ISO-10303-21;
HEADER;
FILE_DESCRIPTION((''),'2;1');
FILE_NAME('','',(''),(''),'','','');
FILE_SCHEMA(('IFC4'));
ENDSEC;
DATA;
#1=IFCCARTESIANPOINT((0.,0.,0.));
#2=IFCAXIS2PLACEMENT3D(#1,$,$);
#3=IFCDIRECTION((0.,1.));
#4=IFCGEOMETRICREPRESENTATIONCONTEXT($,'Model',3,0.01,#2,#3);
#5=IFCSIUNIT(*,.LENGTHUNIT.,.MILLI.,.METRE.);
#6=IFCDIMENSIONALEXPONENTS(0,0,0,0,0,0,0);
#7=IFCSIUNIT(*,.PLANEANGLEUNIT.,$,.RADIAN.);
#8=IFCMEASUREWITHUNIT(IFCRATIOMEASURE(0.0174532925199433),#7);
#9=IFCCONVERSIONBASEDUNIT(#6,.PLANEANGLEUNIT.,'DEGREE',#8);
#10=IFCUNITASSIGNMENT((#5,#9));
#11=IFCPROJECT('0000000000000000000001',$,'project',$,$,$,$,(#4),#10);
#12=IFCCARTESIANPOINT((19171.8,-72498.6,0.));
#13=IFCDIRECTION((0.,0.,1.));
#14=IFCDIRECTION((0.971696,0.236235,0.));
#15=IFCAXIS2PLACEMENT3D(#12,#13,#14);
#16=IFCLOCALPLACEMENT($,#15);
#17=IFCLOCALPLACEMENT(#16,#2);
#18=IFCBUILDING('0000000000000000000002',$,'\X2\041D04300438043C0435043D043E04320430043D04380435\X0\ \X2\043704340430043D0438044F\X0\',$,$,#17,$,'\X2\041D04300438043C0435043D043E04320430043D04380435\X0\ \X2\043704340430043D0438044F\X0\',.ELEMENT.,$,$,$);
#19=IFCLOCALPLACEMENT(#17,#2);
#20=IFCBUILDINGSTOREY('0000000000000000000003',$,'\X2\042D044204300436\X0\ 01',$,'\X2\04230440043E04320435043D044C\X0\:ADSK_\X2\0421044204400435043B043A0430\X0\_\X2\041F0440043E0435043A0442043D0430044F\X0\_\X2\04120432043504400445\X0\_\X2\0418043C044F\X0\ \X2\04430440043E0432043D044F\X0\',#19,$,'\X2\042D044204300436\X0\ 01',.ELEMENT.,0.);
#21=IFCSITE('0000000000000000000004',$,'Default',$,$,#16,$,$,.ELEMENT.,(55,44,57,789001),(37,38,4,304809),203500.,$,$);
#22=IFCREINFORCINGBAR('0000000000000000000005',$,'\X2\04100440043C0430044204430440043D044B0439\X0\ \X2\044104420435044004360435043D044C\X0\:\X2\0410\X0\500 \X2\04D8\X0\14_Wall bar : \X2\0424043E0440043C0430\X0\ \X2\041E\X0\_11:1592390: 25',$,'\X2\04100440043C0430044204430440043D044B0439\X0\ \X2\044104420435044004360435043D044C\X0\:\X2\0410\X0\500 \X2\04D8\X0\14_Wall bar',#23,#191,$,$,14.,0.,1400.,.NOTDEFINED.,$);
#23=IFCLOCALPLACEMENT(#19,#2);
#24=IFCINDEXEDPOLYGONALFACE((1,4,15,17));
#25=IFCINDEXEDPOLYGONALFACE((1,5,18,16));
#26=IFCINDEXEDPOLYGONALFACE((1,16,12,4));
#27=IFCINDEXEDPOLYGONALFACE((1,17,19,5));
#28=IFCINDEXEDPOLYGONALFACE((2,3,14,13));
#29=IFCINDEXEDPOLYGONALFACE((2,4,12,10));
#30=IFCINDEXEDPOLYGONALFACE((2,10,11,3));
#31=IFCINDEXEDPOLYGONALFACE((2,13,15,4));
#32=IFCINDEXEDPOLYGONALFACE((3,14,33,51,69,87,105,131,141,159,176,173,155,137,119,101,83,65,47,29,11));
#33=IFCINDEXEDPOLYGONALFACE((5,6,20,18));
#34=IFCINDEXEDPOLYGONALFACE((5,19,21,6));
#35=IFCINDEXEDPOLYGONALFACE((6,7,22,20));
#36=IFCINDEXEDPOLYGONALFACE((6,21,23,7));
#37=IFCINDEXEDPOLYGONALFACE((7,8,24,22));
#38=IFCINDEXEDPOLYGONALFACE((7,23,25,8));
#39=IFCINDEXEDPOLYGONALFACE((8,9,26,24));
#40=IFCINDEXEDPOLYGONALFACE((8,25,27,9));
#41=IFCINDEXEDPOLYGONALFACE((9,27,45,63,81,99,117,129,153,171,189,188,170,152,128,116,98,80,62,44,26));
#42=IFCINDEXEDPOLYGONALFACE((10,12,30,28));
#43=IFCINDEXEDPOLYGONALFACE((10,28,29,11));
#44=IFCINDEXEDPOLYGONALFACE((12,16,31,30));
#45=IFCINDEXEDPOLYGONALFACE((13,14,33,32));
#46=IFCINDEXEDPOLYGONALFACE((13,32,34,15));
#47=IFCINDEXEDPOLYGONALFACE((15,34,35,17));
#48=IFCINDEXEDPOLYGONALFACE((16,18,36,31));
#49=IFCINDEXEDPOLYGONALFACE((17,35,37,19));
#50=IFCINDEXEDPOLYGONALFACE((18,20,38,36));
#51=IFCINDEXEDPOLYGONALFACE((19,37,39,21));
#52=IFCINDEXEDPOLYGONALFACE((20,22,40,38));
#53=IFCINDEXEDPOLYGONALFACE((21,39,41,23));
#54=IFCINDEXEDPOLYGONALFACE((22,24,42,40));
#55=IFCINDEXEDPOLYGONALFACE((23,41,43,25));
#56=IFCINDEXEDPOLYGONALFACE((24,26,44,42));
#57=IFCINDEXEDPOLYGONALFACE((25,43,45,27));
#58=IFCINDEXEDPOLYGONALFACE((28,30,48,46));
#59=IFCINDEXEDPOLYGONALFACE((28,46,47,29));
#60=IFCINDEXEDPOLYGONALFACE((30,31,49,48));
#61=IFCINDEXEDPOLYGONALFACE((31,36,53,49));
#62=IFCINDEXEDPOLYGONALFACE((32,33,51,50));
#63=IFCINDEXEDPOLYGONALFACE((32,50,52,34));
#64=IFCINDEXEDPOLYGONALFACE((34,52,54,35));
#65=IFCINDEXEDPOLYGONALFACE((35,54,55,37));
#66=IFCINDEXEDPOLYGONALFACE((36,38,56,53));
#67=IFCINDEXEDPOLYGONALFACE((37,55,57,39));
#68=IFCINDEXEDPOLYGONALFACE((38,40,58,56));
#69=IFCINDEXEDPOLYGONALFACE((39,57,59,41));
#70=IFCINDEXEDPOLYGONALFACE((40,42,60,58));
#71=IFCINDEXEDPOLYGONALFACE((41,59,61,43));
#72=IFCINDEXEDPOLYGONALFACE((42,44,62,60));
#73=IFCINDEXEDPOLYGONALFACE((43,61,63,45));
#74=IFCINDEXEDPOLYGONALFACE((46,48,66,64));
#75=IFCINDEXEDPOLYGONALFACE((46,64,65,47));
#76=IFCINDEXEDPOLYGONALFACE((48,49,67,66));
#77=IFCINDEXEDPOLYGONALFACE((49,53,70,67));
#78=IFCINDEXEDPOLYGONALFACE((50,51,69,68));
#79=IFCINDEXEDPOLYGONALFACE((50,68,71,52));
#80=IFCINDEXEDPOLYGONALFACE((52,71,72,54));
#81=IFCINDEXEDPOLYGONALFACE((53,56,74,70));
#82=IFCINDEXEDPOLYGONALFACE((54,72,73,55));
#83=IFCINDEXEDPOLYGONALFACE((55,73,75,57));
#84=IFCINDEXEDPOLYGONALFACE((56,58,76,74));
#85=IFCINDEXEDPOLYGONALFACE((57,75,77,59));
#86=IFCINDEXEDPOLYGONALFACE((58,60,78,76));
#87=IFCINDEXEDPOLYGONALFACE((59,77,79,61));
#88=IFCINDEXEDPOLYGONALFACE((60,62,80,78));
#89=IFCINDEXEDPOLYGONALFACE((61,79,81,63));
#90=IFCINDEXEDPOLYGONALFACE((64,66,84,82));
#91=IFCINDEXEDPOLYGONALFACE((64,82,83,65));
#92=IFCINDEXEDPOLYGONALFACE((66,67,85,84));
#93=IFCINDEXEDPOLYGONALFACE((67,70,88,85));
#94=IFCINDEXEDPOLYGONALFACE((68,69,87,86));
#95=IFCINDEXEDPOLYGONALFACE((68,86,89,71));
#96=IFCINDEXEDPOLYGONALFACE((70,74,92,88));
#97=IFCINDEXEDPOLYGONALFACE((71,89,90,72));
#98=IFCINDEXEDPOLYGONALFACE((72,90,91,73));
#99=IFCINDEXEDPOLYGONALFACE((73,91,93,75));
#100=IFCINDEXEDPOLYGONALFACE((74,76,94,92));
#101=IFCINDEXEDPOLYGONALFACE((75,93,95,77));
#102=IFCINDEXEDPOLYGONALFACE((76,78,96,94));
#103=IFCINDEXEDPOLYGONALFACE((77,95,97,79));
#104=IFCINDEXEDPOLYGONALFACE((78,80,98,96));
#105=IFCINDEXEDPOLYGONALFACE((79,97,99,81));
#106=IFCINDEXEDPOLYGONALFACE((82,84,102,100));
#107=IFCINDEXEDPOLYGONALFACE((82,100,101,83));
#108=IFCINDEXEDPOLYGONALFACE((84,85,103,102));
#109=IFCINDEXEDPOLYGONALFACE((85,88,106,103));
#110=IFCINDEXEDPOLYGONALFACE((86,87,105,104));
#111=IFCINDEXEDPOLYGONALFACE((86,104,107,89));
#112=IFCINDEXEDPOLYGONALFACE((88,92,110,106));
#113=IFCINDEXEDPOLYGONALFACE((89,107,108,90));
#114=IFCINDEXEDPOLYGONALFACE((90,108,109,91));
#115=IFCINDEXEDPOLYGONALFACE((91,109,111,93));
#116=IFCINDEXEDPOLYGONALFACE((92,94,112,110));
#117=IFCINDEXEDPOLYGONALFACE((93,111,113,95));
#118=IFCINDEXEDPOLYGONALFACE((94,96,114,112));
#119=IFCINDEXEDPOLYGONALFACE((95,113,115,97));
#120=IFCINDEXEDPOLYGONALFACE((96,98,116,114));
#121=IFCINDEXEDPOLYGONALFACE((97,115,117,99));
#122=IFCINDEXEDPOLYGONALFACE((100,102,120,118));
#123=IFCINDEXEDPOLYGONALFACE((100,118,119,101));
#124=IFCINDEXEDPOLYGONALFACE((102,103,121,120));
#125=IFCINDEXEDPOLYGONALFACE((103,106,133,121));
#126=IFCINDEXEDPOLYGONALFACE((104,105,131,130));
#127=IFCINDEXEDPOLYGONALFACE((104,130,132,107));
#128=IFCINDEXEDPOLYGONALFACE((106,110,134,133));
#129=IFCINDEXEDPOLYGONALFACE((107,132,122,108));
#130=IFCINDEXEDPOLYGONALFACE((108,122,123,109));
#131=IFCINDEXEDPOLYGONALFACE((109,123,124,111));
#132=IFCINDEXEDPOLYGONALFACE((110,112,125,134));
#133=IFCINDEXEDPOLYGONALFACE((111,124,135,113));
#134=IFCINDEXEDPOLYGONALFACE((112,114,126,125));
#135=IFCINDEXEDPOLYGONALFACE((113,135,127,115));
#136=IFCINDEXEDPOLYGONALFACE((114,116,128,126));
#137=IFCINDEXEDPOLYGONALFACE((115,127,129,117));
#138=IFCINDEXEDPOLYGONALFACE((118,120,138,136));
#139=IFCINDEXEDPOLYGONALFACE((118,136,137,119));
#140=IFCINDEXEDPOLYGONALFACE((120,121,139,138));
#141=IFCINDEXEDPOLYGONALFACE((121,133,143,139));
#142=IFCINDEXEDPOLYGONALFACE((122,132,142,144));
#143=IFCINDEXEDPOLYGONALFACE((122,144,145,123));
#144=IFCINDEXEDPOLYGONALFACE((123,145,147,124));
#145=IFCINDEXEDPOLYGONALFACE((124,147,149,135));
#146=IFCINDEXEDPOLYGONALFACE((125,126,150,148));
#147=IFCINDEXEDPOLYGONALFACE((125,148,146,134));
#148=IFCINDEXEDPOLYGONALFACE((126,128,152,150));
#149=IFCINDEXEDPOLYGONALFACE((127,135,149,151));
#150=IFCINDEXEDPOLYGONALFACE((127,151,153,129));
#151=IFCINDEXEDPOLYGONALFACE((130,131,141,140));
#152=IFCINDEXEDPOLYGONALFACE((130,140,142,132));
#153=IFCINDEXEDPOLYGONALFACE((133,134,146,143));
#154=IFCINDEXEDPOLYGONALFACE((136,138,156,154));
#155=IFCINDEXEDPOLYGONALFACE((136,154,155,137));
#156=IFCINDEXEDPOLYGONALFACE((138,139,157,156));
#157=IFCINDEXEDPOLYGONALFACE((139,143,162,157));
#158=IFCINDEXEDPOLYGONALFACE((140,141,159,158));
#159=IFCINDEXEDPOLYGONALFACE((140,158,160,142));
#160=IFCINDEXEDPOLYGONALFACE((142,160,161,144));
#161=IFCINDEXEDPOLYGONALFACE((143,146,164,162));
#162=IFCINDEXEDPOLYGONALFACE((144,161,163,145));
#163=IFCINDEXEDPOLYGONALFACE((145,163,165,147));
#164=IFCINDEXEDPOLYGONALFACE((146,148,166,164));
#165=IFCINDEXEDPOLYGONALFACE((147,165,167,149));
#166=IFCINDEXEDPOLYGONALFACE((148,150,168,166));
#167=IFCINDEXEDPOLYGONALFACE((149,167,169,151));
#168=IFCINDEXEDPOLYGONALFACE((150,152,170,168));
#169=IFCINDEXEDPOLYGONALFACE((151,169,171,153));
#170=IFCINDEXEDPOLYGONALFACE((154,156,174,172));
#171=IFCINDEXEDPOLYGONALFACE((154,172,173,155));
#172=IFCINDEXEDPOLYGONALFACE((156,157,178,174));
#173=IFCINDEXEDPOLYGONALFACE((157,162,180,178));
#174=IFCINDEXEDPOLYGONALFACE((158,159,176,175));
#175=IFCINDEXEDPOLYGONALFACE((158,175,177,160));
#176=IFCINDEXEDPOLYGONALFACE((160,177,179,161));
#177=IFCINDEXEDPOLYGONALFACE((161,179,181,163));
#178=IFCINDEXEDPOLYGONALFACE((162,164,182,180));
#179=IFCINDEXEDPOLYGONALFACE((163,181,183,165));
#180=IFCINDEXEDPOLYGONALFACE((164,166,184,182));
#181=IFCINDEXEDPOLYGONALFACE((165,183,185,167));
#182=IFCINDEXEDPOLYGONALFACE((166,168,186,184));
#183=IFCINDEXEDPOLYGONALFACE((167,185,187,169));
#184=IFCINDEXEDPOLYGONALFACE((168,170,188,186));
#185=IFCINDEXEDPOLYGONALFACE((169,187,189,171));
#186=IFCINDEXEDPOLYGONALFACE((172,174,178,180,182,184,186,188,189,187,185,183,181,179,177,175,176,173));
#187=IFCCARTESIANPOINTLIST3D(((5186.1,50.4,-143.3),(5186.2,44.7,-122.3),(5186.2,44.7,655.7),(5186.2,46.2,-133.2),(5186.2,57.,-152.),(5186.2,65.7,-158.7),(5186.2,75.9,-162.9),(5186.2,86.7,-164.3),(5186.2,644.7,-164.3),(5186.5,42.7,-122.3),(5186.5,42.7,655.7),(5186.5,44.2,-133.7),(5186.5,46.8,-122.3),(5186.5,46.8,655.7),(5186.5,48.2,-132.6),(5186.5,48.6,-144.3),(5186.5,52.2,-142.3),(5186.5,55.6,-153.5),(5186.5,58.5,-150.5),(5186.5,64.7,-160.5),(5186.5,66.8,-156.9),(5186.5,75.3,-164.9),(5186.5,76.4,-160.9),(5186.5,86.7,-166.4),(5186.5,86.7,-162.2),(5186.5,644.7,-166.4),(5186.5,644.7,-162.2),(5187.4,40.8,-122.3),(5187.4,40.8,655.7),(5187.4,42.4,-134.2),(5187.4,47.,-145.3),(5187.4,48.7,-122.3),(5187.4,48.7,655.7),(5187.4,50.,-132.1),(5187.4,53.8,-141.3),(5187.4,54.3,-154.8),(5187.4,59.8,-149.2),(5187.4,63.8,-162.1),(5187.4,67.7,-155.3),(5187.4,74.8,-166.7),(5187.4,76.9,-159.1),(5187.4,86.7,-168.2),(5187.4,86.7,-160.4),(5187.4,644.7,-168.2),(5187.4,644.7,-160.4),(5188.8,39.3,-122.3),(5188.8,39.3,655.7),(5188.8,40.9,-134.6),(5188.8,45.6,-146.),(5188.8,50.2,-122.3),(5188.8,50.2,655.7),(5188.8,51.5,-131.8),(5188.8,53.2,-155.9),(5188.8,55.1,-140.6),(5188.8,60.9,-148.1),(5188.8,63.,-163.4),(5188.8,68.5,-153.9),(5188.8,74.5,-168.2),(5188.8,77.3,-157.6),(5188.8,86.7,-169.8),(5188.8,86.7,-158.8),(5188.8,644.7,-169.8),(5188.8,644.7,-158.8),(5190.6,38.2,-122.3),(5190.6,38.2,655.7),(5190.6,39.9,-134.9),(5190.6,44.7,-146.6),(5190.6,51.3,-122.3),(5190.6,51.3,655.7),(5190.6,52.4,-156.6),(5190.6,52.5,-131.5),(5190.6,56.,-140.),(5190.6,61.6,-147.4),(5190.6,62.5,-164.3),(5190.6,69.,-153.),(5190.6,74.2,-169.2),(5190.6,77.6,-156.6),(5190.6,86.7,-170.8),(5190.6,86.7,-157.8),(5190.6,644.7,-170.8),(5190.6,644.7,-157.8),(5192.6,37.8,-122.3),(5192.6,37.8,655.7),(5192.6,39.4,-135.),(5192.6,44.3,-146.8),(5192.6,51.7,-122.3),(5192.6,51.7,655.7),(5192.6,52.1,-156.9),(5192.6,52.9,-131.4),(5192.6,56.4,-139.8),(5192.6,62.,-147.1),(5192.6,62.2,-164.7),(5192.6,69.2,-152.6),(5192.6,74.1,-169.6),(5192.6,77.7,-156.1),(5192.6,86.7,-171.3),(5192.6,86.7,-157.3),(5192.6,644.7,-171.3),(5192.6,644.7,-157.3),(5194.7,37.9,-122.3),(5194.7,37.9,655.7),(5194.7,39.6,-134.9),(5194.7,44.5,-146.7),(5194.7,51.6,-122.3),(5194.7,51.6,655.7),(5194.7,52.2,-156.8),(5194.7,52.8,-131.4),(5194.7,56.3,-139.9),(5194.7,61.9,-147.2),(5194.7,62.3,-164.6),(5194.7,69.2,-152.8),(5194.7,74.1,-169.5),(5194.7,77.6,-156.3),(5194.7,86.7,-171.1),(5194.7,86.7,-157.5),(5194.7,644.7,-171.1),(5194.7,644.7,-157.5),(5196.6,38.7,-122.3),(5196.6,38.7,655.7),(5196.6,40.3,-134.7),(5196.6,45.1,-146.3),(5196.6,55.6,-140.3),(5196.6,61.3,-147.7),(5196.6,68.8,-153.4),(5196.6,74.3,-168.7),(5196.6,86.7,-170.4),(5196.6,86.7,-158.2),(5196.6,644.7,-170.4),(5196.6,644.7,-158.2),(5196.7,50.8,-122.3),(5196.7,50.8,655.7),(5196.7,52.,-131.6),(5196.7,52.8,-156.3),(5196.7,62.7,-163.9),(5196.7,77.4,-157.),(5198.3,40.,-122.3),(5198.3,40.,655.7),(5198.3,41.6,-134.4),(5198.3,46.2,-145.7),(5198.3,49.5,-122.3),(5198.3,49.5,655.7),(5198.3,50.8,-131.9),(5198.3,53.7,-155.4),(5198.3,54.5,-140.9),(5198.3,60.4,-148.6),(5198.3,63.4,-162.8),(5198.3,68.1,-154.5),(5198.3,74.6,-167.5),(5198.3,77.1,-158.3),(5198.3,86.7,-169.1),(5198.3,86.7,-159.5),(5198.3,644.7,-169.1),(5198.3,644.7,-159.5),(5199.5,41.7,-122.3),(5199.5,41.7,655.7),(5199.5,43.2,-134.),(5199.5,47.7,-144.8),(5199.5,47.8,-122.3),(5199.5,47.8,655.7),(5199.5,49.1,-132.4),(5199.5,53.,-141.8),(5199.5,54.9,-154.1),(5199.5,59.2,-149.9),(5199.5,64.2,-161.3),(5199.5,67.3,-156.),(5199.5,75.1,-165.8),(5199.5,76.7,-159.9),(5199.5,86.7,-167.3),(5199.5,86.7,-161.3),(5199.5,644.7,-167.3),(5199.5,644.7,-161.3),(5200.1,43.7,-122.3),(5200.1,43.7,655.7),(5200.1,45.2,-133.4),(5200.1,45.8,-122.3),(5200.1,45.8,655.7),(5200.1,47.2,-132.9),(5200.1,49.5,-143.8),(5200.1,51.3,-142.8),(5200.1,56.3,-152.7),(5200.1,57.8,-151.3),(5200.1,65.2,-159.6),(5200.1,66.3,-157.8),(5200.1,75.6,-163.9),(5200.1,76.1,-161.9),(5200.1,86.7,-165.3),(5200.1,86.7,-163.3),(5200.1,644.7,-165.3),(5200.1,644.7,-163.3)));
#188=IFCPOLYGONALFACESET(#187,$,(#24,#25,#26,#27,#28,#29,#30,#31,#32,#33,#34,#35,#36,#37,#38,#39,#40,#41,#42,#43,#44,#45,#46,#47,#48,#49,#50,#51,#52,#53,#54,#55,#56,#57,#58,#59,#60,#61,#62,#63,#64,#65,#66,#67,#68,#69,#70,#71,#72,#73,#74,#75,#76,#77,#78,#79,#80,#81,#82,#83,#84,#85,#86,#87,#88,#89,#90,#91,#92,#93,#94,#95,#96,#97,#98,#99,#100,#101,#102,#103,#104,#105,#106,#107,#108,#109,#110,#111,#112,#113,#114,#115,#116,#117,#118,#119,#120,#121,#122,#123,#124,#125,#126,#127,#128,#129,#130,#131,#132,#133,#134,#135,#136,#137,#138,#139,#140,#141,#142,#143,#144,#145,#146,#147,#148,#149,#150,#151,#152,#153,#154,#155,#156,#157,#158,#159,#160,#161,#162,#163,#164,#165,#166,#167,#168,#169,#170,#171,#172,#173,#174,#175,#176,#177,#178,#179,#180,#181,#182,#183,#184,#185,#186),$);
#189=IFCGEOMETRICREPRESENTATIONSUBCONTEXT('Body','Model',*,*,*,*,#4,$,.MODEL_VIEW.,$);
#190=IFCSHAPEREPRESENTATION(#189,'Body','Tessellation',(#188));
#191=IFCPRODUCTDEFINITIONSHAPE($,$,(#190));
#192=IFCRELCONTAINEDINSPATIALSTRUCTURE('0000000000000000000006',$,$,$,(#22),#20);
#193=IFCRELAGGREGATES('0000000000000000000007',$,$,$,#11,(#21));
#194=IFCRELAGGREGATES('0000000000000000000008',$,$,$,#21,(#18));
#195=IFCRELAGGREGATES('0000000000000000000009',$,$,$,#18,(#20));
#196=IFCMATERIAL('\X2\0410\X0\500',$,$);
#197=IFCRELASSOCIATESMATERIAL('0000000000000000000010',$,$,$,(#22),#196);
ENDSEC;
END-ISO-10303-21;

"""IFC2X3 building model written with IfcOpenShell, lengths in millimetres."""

from ifc_helpers import new_model, entity, si_unit, converted_unit, direction, frame, origin, place, context, subcontext, project, spatial, material, element, save


model = new_model("IFC2X3")

# Units and contexts
model_context = context("Model", 3, precision=0.01, world=origin(), true_north=direction((0.0, 1.0)))
body_context = subcontext(model_context, "Body", "Model", "MODEL_VIEW")
ifc_project = project(units=[si_unit("LENGTHUNIT", "METRE", prefix="MILLI"), converted_unit("PLANEANGLEUNIT", "DEGREE", entity("IfcRatioMeasure", 0.0174532925199433), si_unit("PLANEANGLEUNIT", "RADIAN"), dimensions=[0, 0, 0, 0, 0, 0, 0])], contexts=[model_context])

# Site, building, storey
site_placement = place(None, frame((19171.8, -72498.6, 0.0), z_axis=(0.0, 0.0, 1.0), x_axis=(0.971696, 0.236235, 0.0)))
site = spatial("IfcSite", under=ifc_project, at=site_placement, Name="Default", CompositionType="ELEMENT", RefLatitude=(55, 44, 57, 789001), RefLongitude=(37, 38, 4, 304809), RefElevation=203500.0)
building_placement = place(site_placement, origin())
building = spatial("IfcBuilding", under=site, at=building_placement, Name="Наименование здания", LongName="Наименование здания", CompositionType="ELEMENT")
storey_placement = place(building_placement, origin())
storey = spatial("IfcBuildingStorey", under=building, at=storey_placement, Name="Этаж 01", ObjectType="Уровень:ADSK_Стрелка_Проектная_Вверх_Имя уровня", LongName="Этаж 01", CompositionType="ELEMENT", Elevation=0.0)

# Reinforcing bar
ifc_material = material(Name="А500")
placement = place(storey_placement, origin())
element("IfcReinforcingBar", 1, at=placement, inside=storey, material=ifc_material, Name="Арматурный стержень:А500 Ә14_Wall bar : Форма О_11:1592390: 25", ObjectType="Арматурный стержень:А500 Ә14_Wall bar", BarLength=1400.0, BarRole="NOTDEFINED", CrossSectionArea=0.0, NominalDiameter=14.0, context=body_context, shape_type="AdvancedSweptSolid", body=[
    entity("IfcSweptDiskSolid", entity("IfcCompositeCurve", [entity("IfcCompositeCurveSegment", "CONTINUOUS", True, entity("IfcPolyline", [entity("IfcCartesianPoint", [5193.1, 44.7, 655.7]), entity("IfcCartesianPoint", [5193.1, 44.7, -122.3])])), entity("IfcCompositeCurveSegment", "CONTINUOUS", True, entity("IfcTrimmedCurve", entity("IfcCircle", entity("IfcAxis2Placement3D", entity("IfcCartesianPoint", [5193.1, 86.7, -122.3]), entity("IfcDirection", [1.0, 0.0, 0.0]), entity("IfcDirection", [0.0, 0.0, -1.0])), 42.0), [entity("IfcParameterValue", 270.0)], [entity("IfcParameterValue", 360.0)], True, "PARAMETER")), entity("IfcCompositeCurveSegment", "CONTINUOUS", True, entity("IfcPolyline", [entity("IfcCartesianPoint", [5193.1, 86.7, -164.3]), entity("IfcCartesianPoint", [5193.1, 644.7, -164.3])]))], False), 7.0, None, 0.0, 92.0),
])

save(model, "model.ifc")
